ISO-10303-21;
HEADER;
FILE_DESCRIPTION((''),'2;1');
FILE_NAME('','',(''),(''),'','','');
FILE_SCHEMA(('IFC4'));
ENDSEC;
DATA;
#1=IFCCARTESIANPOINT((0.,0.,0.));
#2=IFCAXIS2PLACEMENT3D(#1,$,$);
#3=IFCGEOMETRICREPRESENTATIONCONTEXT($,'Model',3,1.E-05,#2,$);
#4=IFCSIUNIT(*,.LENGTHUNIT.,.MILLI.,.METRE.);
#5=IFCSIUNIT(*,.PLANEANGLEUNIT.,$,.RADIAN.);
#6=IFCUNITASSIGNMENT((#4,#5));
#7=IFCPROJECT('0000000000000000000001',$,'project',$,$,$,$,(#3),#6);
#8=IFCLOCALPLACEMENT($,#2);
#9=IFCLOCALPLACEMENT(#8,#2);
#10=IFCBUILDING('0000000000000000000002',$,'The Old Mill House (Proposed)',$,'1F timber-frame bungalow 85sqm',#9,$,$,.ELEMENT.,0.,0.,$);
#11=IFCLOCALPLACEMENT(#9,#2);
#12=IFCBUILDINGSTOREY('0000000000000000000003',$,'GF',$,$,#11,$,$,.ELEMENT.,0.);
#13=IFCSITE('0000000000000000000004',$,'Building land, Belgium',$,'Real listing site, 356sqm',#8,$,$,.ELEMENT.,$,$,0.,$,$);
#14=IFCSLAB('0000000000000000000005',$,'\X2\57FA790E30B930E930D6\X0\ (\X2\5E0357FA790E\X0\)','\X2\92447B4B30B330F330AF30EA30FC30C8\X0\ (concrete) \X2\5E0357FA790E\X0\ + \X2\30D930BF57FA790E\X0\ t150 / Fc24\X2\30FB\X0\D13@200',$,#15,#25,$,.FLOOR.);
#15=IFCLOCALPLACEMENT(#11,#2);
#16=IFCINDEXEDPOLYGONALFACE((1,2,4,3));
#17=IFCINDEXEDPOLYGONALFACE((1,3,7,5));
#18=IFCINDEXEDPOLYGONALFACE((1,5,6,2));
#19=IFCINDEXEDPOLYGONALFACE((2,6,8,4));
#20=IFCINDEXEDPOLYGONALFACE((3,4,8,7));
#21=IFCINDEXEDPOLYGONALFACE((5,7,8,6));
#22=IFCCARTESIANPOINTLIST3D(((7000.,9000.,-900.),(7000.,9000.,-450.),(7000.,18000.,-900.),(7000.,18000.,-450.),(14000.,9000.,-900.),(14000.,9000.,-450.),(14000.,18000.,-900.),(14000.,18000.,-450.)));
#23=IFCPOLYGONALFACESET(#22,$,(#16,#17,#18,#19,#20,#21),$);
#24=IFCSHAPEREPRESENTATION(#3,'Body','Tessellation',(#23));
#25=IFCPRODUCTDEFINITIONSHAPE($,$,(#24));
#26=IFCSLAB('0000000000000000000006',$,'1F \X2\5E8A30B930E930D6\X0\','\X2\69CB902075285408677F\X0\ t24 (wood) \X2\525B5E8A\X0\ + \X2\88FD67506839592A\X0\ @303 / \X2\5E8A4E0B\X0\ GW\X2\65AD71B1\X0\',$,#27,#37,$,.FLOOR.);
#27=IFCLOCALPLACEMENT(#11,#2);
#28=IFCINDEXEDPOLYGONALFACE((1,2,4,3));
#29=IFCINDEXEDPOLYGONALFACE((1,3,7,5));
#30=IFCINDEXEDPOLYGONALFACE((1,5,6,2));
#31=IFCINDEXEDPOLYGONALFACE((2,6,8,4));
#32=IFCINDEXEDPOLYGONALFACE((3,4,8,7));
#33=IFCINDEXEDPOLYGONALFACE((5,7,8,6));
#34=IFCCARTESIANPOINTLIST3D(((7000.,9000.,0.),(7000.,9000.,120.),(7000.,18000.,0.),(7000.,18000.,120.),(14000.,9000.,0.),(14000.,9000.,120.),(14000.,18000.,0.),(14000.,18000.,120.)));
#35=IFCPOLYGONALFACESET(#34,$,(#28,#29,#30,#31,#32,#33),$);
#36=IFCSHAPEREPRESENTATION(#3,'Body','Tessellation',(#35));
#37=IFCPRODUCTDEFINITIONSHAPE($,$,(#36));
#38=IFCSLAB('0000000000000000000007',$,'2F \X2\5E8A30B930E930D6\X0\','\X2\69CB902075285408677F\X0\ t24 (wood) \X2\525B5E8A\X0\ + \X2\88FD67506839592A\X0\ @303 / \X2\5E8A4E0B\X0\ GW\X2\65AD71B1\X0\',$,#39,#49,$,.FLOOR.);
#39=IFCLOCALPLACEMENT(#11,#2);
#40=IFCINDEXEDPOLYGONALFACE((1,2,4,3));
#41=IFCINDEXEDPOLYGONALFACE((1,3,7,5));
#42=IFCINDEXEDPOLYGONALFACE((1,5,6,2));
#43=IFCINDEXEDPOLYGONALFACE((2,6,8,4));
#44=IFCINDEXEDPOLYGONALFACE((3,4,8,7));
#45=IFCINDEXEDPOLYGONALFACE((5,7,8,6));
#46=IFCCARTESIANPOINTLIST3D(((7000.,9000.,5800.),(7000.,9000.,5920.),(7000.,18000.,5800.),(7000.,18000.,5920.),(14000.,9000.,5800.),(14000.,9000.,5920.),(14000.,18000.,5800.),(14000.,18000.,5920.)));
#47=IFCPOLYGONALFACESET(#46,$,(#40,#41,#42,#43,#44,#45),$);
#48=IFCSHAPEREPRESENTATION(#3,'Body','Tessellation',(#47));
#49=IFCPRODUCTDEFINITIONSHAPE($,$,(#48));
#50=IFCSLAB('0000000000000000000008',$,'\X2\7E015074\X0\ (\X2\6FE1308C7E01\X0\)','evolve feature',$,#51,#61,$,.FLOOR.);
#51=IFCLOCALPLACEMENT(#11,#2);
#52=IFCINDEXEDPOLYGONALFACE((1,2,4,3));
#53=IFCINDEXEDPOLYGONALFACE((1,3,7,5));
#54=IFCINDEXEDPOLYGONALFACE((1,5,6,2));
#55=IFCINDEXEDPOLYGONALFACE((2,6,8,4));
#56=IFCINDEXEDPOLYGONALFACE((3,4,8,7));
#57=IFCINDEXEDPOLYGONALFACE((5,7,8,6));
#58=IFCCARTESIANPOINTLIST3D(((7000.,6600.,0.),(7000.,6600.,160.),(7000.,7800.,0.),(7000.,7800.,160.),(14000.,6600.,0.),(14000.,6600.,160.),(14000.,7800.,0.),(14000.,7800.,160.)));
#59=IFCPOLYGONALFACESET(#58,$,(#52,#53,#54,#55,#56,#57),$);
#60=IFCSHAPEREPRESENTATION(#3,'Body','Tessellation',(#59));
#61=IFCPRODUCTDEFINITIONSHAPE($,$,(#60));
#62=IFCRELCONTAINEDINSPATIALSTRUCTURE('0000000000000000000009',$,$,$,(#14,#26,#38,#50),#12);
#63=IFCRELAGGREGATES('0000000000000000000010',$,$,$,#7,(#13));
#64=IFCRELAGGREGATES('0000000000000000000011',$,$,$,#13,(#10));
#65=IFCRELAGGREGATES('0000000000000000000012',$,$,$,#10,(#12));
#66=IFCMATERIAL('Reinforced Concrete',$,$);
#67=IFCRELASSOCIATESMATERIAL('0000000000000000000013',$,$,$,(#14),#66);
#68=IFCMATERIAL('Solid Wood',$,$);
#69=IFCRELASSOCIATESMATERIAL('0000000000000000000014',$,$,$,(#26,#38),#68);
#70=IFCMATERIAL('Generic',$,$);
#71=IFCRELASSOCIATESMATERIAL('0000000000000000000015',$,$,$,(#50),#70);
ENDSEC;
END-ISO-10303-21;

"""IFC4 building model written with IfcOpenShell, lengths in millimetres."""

from ifc_helpers import new_model, si_unit, frame, frame_2d, origin, place, context, project, spatial, rectangle, extrude, material, element, save


model = new_model("IFC4")

# Units and contexts
model_context = context("Model", 3, precision=1e-05, world=origin())
ifc_project = project(units=[si_unit("LENGTHUNIT", "METRE", prefix="MILLI"), si_unit("PLANEANGLEUNIT", "RADIAN")], contexts=[model_context])

# Site, building, storey
site_placement = place(None, origin())
site = spatial("IfcSite", under=ifc_project, at=site_placement, Name="Building land, Belgium", ObjectType="Real listing site, 356sqm", CompositionType="ELEMENT", RefElevation=0.0)
building_placement = place(site_placement, origin())
building = spatial("IfcBuilding", under=site, at=building_placement, Name="The Old Mill House (Proposed)", ObjectType="1F timber-frame bungalow 85sqm", CompositionType="ELEMENT", ElevationOfRefHeight=0.0, ElevationOfTerrain=0.0)
storey_placement = place(building_placement, origin())
storey = spatial("IfcBuildingStorey", under=building, at=storey_placement, Name="GF", CompositionType="ELEMENT", Elevation=0.0)

# Slabs
ifc_material_1 = material(Name="Reinforced Concrete")
slab_1_placement = place(storey_placement, frame((3500.0, 4500.0, -450.0)))
element("IfcSlab", 1, at=slab_1_placement, inside=storey, material=ifc_material_1, Name="基礎スラブ (布基礎)", Description="鉄筋コンクリート (concrete) 布基礎 + ベタ基礎 t150 / Fc24・D13@200", PredefinedType="FLOOR", context=model_context, shape_type="SweptSolid", body=[
    extrude(rectangle(XDim=7000.0, YDim=9000.0, at=frame_2d((3500.0, 4500.0))), frame((3500.0, 4500.0, -450.0)), (0.0, 0.0, 1.0), 450.0),
])
ifc_material_2 = material(Name="Solid Wood")
slab_2_placement = place(storey_placement, frame((3500.0, 4500.0, 0.0)))
element("IfcSlab", 2, at=slab_2_placement, inside=storey, material=ifc_material_2, Name="1F 床スラブ", Description="構造用合板 t24 (wood) 剛床 + 製材根太 @303 / 床下 GW断熱", PredefinedType="FLOOR", context=model_context, shape_type="SweptSolid", body=[
    extrude(rectangle(XDim=7000.0, YDim=9000.0, at=frame_2d((3500.0, 4500.0))), frame((3500.0, 4500.0, 0.0)), (0.0, 0.0, 1.0), 120.0),
])
slab_3_placement = place(storey_placement, frame((3500.0, 4500.0, 2900.0)))
element("IfcSlab", 3, at=slab_3_placement, inside=storey, material=ifc_material_2, Name="2F 床スラブ", Description="構造用合板 t24 (wood) 剛床 + 製材根太 @303 / 床下 GW断熱", PredefinedType="FLOOR", context=model_context, shape_type="SweptSolid", body=[
    extrude(rectangle(XDim=7000.0, YDim=9000.0, at=frame_2d((3500.0, 4500.0))), frame((3500.0, 4500.0, 2900.0)), (0.0, 0.0, 1.0), 120.0),
])
ifc_material_3 = material(Name="Generic")
slab_4_placement = place(storey_placement, frame((3500.0, 3300.0, 0.0)))
element("IfcSlab", 4, at=slab_4_placement, inside=storey, material=ifc_material_3, Name="縁側 (濡れ縁)", Description="evolve feature", PredefinedType="FLOOR", context=model_context, shape_type="SweptSolid", body=[
    extrude(rectangle(XDim=7000.0, YDim=1200.0, at=frame_2d((3500.0, 600.0))), frame((3500.0, 3300.0, 0.0)), (0.0, 0.0, 1.0), 160.0),
])

save(model, "model.ifc")
